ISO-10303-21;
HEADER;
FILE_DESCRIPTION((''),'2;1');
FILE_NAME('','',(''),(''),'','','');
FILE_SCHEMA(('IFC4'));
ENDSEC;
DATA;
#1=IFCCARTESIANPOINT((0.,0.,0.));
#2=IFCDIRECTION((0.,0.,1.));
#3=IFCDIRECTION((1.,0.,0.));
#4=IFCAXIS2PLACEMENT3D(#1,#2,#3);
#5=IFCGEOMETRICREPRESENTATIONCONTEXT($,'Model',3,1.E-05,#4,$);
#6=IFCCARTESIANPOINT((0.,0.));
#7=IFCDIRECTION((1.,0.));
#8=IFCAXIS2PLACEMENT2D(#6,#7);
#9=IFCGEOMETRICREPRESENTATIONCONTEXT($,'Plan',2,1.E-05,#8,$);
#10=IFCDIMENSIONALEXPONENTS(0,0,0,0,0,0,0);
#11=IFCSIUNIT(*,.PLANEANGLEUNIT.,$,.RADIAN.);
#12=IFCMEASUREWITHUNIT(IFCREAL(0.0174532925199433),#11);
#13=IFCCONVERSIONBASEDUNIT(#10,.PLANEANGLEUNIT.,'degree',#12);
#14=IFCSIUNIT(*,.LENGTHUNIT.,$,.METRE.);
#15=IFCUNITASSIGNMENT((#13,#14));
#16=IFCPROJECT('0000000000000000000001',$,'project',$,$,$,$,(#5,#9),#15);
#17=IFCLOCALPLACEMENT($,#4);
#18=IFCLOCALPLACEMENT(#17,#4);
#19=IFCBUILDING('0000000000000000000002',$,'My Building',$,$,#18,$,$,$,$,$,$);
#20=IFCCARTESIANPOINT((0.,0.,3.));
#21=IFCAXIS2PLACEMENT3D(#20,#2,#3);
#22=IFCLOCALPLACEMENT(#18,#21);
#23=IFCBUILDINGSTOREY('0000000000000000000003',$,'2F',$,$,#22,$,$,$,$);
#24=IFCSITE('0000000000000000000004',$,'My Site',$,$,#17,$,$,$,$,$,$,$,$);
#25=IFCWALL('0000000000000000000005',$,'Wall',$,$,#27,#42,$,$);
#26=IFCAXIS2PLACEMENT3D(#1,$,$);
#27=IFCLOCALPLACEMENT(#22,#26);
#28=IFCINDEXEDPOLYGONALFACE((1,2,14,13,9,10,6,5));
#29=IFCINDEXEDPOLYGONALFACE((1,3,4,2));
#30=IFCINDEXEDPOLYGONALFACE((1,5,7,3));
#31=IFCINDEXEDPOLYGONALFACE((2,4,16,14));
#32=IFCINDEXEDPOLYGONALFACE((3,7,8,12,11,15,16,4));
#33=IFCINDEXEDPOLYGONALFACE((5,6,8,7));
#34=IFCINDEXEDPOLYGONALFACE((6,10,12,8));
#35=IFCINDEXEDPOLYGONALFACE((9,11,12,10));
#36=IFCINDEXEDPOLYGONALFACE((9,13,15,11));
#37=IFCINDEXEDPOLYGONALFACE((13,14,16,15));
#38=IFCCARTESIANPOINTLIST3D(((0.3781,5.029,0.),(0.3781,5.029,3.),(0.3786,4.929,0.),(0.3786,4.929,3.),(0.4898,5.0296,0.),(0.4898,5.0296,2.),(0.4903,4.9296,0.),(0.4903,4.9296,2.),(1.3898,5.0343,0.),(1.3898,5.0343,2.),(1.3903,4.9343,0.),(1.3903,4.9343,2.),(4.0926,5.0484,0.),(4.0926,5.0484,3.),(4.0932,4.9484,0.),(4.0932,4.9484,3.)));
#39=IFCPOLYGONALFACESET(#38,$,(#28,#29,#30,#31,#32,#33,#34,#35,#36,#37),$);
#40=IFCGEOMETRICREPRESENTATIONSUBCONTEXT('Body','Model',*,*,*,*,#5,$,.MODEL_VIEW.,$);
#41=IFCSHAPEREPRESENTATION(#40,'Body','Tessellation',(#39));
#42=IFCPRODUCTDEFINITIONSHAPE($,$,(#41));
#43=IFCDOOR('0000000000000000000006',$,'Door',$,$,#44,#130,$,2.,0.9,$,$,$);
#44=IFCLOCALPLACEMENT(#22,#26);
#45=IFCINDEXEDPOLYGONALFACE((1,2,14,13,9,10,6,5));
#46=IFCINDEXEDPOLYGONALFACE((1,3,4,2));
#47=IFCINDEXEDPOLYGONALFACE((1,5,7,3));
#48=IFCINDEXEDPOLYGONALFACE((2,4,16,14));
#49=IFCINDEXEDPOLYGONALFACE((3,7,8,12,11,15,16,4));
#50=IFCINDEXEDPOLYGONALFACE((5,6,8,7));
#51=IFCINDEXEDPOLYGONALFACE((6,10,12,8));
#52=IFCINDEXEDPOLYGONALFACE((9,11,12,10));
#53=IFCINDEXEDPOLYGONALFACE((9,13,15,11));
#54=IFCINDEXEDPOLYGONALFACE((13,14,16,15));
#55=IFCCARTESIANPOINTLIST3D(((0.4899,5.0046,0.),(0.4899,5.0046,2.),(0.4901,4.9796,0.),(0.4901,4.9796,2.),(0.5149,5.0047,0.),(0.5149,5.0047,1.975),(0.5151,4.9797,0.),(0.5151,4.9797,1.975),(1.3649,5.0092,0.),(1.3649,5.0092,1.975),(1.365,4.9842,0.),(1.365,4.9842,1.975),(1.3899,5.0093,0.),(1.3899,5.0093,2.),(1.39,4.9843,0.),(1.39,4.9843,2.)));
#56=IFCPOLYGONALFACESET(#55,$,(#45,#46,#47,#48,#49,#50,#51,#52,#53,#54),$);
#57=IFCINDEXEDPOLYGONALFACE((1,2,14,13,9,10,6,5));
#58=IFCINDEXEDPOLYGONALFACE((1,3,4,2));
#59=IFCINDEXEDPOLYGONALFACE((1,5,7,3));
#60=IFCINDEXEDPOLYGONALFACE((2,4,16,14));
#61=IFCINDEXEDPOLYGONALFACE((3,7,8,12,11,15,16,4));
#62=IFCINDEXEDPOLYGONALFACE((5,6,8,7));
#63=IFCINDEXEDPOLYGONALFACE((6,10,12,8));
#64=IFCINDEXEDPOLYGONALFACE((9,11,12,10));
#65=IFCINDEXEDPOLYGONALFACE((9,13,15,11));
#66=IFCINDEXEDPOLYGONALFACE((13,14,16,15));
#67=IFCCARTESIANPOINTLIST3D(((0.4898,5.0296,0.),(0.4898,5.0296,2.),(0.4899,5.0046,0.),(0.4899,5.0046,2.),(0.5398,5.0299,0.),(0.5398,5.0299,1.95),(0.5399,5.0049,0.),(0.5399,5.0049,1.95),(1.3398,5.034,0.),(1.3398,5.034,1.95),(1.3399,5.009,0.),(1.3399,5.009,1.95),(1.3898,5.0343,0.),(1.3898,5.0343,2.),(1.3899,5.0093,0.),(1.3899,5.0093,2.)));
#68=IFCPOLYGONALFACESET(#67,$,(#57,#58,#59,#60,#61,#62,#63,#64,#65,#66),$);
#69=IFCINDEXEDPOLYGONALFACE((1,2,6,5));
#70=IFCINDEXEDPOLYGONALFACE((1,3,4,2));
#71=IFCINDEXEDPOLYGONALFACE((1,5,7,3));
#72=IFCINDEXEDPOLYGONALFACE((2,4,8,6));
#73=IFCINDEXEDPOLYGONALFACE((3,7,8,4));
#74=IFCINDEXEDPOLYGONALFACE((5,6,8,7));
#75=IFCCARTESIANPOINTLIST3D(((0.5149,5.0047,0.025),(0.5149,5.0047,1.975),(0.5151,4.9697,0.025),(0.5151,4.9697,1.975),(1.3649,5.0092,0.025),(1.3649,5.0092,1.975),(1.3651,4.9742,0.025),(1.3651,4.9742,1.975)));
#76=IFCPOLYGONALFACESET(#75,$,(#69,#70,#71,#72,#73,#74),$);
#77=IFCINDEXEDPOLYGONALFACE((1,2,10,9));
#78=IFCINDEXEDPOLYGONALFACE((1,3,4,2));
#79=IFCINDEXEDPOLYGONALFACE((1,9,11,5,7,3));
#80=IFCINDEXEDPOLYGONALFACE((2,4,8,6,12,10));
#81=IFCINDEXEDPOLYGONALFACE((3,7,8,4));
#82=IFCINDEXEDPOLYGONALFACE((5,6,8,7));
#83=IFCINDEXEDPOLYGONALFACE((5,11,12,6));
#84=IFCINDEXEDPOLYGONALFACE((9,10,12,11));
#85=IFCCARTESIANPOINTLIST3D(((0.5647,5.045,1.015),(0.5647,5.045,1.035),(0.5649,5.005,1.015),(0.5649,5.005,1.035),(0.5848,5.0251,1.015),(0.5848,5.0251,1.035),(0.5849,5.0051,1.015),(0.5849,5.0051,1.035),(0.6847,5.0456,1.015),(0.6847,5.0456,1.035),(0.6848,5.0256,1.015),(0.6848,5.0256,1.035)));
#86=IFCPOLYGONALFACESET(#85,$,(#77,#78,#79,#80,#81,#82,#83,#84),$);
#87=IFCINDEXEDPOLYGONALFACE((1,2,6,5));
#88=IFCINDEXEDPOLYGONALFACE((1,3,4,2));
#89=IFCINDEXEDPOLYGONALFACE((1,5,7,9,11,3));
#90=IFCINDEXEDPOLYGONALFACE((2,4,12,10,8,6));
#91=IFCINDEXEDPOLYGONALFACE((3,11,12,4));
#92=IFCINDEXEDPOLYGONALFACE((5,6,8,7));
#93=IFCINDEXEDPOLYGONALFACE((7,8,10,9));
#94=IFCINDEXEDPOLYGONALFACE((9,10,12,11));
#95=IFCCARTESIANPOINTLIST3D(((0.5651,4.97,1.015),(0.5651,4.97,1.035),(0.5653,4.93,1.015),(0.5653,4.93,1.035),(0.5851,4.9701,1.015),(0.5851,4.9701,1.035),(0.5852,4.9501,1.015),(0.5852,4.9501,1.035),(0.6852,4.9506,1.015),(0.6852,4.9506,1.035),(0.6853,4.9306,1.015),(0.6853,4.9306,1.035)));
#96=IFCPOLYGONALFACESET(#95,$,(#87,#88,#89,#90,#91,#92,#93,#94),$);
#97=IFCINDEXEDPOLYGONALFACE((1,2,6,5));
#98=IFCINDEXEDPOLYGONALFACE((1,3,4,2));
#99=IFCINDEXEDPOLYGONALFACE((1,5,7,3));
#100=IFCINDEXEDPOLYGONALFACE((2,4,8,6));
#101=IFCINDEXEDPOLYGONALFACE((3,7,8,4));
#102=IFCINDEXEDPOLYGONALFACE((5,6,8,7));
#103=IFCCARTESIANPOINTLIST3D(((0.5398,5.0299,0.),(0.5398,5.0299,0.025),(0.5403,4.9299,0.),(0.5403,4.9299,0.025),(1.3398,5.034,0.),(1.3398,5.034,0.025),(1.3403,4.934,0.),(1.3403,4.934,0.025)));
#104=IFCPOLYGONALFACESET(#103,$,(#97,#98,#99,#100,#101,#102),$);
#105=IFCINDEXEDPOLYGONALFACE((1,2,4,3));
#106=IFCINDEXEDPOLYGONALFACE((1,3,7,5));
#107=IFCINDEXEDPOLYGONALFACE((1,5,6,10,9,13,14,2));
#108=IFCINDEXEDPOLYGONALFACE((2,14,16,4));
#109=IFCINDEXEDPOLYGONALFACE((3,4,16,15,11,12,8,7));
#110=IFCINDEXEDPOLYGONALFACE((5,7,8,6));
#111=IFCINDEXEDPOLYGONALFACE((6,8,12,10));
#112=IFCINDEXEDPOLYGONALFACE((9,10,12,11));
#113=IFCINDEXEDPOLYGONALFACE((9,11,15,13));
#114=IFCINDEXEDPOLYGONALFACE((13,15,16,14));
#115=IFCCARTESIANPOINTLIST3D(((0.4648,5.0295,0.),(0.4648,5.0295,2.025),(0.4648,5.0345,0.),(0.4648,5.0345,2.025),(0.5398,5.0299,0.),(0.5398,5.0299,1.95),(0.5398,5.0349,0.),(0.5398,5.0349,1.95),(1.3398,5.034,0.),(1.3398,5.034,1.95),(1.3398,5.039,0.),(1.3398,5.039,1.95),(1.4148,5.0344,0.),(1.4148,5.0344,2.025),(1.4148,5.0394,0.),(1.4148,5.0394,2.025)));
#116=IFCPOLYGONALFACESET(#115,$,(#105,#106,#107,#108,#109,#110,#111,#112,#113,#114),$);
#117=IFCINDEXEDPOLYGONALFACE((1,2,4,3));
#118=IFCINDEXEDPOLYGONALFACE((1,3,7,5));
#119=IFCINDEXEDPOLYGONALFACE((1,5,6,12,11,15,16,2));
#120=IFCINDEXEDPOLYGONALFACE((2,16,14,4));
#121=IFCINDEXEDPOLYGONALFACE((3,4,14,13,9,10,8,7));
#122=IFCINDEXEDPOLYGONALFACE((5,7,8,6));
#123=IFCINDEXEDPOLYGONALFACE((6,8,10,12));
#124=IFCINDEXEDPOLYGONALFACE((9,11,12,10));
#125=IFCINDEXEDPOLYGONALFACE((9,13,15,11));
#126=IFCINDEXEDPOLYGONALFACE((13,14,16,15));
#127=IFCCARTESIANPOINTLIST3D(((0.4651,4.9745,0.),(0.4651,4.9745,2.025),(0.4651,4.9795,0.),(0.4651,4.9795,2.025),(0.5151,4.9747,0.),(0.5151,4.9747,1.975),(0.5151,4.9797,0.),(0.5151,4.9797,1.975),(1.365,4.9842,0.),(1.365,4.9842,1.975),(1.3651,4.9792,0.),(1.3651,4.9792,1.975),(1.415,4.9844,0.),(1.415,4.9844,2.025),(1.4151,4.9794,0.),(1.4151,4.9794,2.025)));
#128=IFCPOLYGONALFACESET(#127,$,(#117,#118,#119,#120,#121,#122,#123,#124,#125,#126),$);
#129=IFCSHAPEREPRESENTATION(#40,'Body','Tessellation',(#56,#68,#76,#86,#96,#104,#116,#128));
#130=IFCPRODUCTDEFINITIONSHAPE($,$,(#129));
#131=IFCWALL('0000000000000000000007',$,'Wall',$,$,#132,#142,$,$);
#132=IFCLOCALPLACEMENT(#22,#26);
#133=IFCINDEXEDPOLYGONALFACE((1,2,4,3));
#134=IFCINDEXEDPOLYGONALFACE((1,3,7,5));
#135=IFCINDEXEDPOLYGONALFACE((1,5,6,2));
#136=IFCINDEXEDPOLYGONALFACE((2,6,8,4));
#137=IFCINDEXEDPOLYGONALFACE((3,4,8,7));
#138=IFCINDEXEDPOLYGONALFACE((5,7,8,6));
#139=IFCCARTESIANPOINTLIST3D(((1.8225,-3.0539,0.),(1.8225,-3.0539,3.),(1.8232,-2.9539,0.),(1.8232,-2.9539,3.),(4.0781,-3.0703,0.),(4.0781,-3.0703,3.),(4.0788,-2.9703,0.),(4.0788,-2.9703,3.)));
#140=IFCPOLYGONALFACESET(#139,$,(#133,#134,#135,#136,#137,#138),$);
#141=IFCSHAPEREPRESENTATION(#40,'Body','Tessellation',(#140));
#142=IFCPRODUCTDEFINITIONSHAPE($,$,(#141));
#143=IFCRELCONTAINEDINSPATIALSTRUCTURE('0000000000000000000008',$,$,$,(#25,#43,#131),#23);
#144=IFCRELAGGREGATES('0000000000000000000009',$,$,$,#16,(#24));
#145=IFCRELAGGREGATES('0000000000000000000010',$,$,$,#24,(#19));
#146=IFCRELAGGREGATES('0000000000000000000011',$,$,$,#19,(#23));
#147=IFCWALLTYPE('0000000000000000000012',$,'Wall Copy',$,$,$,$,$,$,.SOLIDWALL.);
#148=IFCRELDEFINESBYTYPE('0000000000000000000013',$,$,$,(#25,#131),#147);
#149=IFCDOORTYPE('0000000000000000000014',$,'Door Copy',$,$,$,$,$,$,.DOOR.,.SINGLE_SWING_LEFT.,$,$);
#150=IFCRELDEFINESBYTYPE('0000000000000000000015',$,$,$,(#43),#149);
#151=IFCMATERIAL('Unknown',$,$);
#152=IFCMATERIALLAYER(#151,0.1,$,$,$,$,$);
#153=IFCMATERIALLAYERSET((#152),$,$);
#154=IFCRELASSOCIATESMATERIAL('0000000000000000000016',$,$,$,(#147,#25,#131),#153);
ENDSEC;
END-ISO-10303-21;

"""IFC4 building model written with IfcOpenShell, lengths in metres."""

from ifc_helpers import new_model, entity, si_unit, converted_unit, frame, origin_with_axes, origin_2d_with_axis, place, context, subcontext, project, spatial, line, indexed_curve, outline, extrude, shape, source, transform, mapped, material, layer, layer_set, layer_usage, type_object, type_shapes, element, fill, save


model = new_model("IFC4")

# Units and contexts
model_context = context("Model", 3, precision=1e-05, world=origin_with_axes())
plan_context = context("Plan", 2, precision=1e-05, world=origin_2d_with_axis())
body_context_1 = subcontext(model_context, "Body", "Model", "MODEL_VIEW")
body_context_2 = subcontext(plan_context, "Body", "Plan", "PLAN_VIEW")
ifc_project = project(units=[converted_unit("PLANEANGLEUNIT", "degree", entity("IfcReal", 0.0174532925199433), si_unit("PLANEANGLEUNIT", "RADIAN"), dimensions=[0, 0, 0, 0, 0, 0, 0]), si_unit("LENGTHUNIT", "METRE")], contexts=[model_context, plan_context])

# Site, building, storey
site_placement = place(None, origin_with_axes())
site = spatial("IfcSite", under=ifc_project, at=site_placement, Name="My Site")
building_placement = place(site_placement, origin_with_axes())
building = spatial("IfcBuilding", under=site, at=building_placement, Name="My Building")
storey_placement = place(building_placement, frame((0.0, 0.0, 3.0), z_axis=(0.0, 0.0, 1.0), x_axis=(1.0, 0.0, 0.0)))
storey = spatial("IfcBuildingStorey", under=building, at=storey_placement, Name="2F")

# Shared definitions
ifc_material = material(Name="Unknown")

# Shared definitions
ifc_layer_1 = layer(ifc_material, 0.1)
ifc_layer_set_1 = layer_set([ifc_layer_1])
wall_type = type_object("IfcWallType", Name="Wall Copy", PredefinedType="SOLIDWALL", material=ifc_layer_set_1)
shared_shape_1 = source(origin_with_axes(), body_context_1, "Body", "SweptSolid", [
    extrude(outline(indexed_curve([(0.0, 0.0), (0.9, 0.0), (0.9, 2.0), (0.0, 2.0)], segments=[line(1, 2, 3, 4, 1)])), frame((0.0, -0.6, 0.0), z_axis=(0.0, -1.0, 0.0), x_axis=(1.0, 0.0, 0.0)), (0.0, 0.0, -1.0), 1.2),
])
door_type = type_object("IfcDoorType", Name="Door Copy", OperationType="SINGLE_SWING_LEFT", PredefinedType="DOOR")
shared_shape_2 = source(origin_with_axes(), body_context_1, "Body", "SweptSolid", [
    extrude(outline(indexed_curve([(0.0, 0.0), (0.0, 2.0), (0.9, 2.0), (0.9, 0.0), (0.875, 0.0), (0.875, 1.975), (0.025, 1.975), (0.025, 0.0)], segments=[line(1, 2, 3, 4, 5, 6, 7, 8, 1)])), frame((0.0, 0.025, 0.0), z_axis=(0.0, -1.0, 0.0), x_axis=(1.0, 0.0, 0.0)), (0.0, 0.0, -1.0), 0.025),
    extrude(outline(indexed_curve([(0.0, 0.0), (0.0, 2.0), (0.9, 2.0), (0.9, 0.0), (0.85, 0.0), (0.85, 1.95), (0.05, 1.95), (0.05, 0.0)], segments=[line(1, 2, 3, 4, 5, 6, 7, 8, 1)])), frame((0.0, 0.0, 0.0), z_axis=(0.0, -1.0, 0.0), x_axis=(1.0, 0.0, 0.0)), (0.0, 0.0, -1.0), 0.025),
    extrude(outline(indexed_curve([(0.0, 0.0), (0.85, 0.0), (0.85, 0.035), (0.0, 0.035)], segments=[line(1, 2, 3, 4, 1)])), frame((0.025, 0.025, 0.025), z_axis=(0.0, 0.0, 1.0), x_axis=(1.0, 0.0, 0.0)), (0.0, 0.0, 1.0), 1.95),
    extrude(outline(indexed_curve([(0.0, 0.0), (0.0, -0.04), (-0.12, -0.04), (-0.12, -0.02), (-0.02, -0.02), (-0.02, 0.0)], segments=[line(1, 2, 3, 4, 5, 6, 1)])), frame((0.825, 0.025, 1.015), z_axis=(0.0, 0.0, 1.0), x_axis=(1.0, 0.0, 0.0)), (0.0, 0.0, 1.0), 0.02),
    extrude(outline(indexed_curve([(0.0, 0.0), (0.0, 0.04), (-0.12, 0.04), (-0.12, 0.02), (-0.02, 0.02), (-0.02, 0.0)], segments=[line(1, 2, 3, 4, 5, 6, 1)])), frame((0.825, 0.06, 1.015), z_axis=(0.0, 0.0, 1.0), x_axis=(1.0, 0.0, 0.0)), (0.0, 0.0, 1.0), 0.02),
    extrude(outline(indexed_curve([(0.0, 0.0), (0.8, 0.0), (0.8, 0.1), (0.0, 0.1)], segments=[line(1, 2, 3, 4, 1)])), frame((0.05, 0.0, 0.0), z_axis=(0.0, 0.0, 1.0), x_axis=(1.0, 0.0, 0.0)), (0.0, 0.0, 1.0), 0.025),
    extrude(outline(indexed_curve([(0.0, 0.0), (0.0, 2.025), (0.95, 2.025), (0.95, 0.0), (0.875, 0.0), (0.875, 1.95), (0.075, 1.95), (0.075, 0.0)], segments=[line(1, 2, 3, 4, 5, 6, 7, 8, 1)])), frame((-0.025, -0.005, 0.0), z_axis=(0.0, -1.0, 0.0), x_axis=(1.0, 0.0, 0.0)), (0.0, 0.0, -1.0), 0.005),
    extrude(outline(indexed_curve([(0.0, 0.0), (0.0, 2.025), (0.95, 2.025), (0.95, 0.0), (0.9, 0.0), (0.9, 1.975), (0.05, 1.975), (0.05, 0.0)], segments=[line(1, 2, 3, 4, 5, 6, 7, 8, 1)])), frame((-0.025, 0.05, 0.0), z_axis=(0.0, -1.0, 0.0), x_axis=(1.0, 0.0, 0.0)), (0.0, 0.0, -1.0), 0.005),
])
shared_shape_3 = source(origin_with_axes(), body_context_2, "Body", "Curve2D", [
    entity("IfcIndexedPolyCurve", entity("IfcCartesianPointList2D", [[0.0, 0.0], [0.0, 0.05], [0.025, 0.05], [0.025, 0.025], [0.05, 0.025], [0.05, 0.0]]), [entity("IfcLineIndex", [1, 2, 3, 4, 5, 6, 1])]),
    entity("IfcIndexedPolyCurve", entity("IfcCartesianPointList2D", [[0.9, 0.0], [0.9, 0.05], [0.875, 0.05], [0.875, 0.025], [0.85, 0.025], [0.85, 0.0]]), [entity("IfcLineIndex", [1, 2, 3, 4, 5, 6, 1])]),
    entity("IfcTrimmedCurve", entity("IfcEllipse", entity("IfcAxis2Placement2D", entity("IfcCartesianPoint", [0.06, 0.05]), entity("IfcDirection", [1.0, 0.0])), 0.815, 0.85), [entity("IfcCartesianPoint", [0.875, 0.05])], [entity("IfcCartesianPoint", [0.06, 0.9])], True, "CARTESIAN"),
    entity("IfcIndexedPolyCurve", entity("IfcCartesianPointList2D", [[0.025, 0.05], [0.06, 0.05], [0.06, 0.9], [0.025, 0.9]]), [entity("IfcLineIndex", [1, 2, 3, 4, 1])]),
])
type_shapes(door_type, [shared_shape_2, shared_shape_3])

# Wall, opening, door
ifc_layer_usage_1 = layer_usage(ifc_layer_set_1, "AXIS2", "POSITIVE", 0.0)
wall_1_placement = place(storey_placement, frame((4.0926, 5.0484, 0.0), z_axis=(0.0, 0.0, 1.0), x_axis=(-0.999986, -0.005221, 0.0)))
wall_1 = element("IfcWall", 1, at=wall_1_placement, inside=storey, type_object=wall_type, material=ifc_layer_usage_1, Name="Wall", context=body_context_1, shape_type="SweptSolid", body=[
    extrude(outline(indexed_curve([(0.0, 0.0), (0.0, 0.1), (3.7146, 0.1), (3.7146, 0.0)], segments=[line(1, 2, 3, 4, 1)])), origin_with_axes(), (0.0, 0.0, 1.0), 3.0),
])
opening_1_placement = place(wall_1_placement, frame((2.7029, 0.0, 0.0), z_axis=(0.0, 0.0, 1.0), x_axis=(1.0, 0.0, 0.0)))
opening_1 = element("IfcOpeningElement", 2, at=opening_1_placement, cuts=wall_1, PredefinedType="OPENING", context=body_context_1, shape_type="MappedRepresentation", body=[
    mapped(shared_shape_1, transform((0.0, 0.0, 0.0), x_axis=(1.0, 0.0, 0.0), y_axis=(0.0, 1.0, 0.0), z_axis=(0.0, 0.0, 1.0), scale=1.0)),
])
door_1_placement = place(opening_1_placement, origin_with_axes())
door_1 = element("IfcDoor", 3, at=door_1_placement, inside=storey, type_object=door_type, Name="Door", OverallHeight=2.0, OverallWidth=0.9, shapes=[
    shape(body_context_1, "Body", "MappedRepresentation", [mapped(shared_shape_2, transform((0.0, 0.0, 0.0), x_axis=(1.0, 0.0, 0.0), y_axis=(0.0, 1.0, 0.0), z_axis=(0.0, 0.0, 1.0), scale=1.0))]),
    shape(body_context_2, "Body", "MappedRepresentation", [mapped(shared_shape_3, transform((0.0, 0.0, 0.0), x_axis=(1.0, 0.0, 0.0), y_axis=(0.0, 1.0, 0.0), z_axis=(0.0, 0.0, 1.0), scale=1.0))]),
])
fill(opening_1, door_1)

# Wall
ifc_layer_usage_2 = layer_usage(ifc_layer_set_1, "AXIS2", "POSITIVE", 0.0)
wall_2_placement = place(storey_placement, frame((1.8225, -3.0539, 0.0), z_axis=(0.0, 0.0, 1.0), x_axis=(0.999974, -0.007265, 0.0)))
element("IfcWall", 4, at=wall_2_placement, inside=storey, type_object=wall_type, material=ifc_layer_usage_2, Name="Wall", context=body_context_1, shape_type="SweptSolid", body=[
    extrude(outline(indexed_curve([(0.0, 0.0), (0.0, 0.1), (2.2557, 0.1), (2.2557, 0.0)], segments=[line(1, 2, 3, 4, 1)])), origin_with_axes(), (0.0, 0.0, 1.0), 3.0),
])

save(model, "model.ifc")
